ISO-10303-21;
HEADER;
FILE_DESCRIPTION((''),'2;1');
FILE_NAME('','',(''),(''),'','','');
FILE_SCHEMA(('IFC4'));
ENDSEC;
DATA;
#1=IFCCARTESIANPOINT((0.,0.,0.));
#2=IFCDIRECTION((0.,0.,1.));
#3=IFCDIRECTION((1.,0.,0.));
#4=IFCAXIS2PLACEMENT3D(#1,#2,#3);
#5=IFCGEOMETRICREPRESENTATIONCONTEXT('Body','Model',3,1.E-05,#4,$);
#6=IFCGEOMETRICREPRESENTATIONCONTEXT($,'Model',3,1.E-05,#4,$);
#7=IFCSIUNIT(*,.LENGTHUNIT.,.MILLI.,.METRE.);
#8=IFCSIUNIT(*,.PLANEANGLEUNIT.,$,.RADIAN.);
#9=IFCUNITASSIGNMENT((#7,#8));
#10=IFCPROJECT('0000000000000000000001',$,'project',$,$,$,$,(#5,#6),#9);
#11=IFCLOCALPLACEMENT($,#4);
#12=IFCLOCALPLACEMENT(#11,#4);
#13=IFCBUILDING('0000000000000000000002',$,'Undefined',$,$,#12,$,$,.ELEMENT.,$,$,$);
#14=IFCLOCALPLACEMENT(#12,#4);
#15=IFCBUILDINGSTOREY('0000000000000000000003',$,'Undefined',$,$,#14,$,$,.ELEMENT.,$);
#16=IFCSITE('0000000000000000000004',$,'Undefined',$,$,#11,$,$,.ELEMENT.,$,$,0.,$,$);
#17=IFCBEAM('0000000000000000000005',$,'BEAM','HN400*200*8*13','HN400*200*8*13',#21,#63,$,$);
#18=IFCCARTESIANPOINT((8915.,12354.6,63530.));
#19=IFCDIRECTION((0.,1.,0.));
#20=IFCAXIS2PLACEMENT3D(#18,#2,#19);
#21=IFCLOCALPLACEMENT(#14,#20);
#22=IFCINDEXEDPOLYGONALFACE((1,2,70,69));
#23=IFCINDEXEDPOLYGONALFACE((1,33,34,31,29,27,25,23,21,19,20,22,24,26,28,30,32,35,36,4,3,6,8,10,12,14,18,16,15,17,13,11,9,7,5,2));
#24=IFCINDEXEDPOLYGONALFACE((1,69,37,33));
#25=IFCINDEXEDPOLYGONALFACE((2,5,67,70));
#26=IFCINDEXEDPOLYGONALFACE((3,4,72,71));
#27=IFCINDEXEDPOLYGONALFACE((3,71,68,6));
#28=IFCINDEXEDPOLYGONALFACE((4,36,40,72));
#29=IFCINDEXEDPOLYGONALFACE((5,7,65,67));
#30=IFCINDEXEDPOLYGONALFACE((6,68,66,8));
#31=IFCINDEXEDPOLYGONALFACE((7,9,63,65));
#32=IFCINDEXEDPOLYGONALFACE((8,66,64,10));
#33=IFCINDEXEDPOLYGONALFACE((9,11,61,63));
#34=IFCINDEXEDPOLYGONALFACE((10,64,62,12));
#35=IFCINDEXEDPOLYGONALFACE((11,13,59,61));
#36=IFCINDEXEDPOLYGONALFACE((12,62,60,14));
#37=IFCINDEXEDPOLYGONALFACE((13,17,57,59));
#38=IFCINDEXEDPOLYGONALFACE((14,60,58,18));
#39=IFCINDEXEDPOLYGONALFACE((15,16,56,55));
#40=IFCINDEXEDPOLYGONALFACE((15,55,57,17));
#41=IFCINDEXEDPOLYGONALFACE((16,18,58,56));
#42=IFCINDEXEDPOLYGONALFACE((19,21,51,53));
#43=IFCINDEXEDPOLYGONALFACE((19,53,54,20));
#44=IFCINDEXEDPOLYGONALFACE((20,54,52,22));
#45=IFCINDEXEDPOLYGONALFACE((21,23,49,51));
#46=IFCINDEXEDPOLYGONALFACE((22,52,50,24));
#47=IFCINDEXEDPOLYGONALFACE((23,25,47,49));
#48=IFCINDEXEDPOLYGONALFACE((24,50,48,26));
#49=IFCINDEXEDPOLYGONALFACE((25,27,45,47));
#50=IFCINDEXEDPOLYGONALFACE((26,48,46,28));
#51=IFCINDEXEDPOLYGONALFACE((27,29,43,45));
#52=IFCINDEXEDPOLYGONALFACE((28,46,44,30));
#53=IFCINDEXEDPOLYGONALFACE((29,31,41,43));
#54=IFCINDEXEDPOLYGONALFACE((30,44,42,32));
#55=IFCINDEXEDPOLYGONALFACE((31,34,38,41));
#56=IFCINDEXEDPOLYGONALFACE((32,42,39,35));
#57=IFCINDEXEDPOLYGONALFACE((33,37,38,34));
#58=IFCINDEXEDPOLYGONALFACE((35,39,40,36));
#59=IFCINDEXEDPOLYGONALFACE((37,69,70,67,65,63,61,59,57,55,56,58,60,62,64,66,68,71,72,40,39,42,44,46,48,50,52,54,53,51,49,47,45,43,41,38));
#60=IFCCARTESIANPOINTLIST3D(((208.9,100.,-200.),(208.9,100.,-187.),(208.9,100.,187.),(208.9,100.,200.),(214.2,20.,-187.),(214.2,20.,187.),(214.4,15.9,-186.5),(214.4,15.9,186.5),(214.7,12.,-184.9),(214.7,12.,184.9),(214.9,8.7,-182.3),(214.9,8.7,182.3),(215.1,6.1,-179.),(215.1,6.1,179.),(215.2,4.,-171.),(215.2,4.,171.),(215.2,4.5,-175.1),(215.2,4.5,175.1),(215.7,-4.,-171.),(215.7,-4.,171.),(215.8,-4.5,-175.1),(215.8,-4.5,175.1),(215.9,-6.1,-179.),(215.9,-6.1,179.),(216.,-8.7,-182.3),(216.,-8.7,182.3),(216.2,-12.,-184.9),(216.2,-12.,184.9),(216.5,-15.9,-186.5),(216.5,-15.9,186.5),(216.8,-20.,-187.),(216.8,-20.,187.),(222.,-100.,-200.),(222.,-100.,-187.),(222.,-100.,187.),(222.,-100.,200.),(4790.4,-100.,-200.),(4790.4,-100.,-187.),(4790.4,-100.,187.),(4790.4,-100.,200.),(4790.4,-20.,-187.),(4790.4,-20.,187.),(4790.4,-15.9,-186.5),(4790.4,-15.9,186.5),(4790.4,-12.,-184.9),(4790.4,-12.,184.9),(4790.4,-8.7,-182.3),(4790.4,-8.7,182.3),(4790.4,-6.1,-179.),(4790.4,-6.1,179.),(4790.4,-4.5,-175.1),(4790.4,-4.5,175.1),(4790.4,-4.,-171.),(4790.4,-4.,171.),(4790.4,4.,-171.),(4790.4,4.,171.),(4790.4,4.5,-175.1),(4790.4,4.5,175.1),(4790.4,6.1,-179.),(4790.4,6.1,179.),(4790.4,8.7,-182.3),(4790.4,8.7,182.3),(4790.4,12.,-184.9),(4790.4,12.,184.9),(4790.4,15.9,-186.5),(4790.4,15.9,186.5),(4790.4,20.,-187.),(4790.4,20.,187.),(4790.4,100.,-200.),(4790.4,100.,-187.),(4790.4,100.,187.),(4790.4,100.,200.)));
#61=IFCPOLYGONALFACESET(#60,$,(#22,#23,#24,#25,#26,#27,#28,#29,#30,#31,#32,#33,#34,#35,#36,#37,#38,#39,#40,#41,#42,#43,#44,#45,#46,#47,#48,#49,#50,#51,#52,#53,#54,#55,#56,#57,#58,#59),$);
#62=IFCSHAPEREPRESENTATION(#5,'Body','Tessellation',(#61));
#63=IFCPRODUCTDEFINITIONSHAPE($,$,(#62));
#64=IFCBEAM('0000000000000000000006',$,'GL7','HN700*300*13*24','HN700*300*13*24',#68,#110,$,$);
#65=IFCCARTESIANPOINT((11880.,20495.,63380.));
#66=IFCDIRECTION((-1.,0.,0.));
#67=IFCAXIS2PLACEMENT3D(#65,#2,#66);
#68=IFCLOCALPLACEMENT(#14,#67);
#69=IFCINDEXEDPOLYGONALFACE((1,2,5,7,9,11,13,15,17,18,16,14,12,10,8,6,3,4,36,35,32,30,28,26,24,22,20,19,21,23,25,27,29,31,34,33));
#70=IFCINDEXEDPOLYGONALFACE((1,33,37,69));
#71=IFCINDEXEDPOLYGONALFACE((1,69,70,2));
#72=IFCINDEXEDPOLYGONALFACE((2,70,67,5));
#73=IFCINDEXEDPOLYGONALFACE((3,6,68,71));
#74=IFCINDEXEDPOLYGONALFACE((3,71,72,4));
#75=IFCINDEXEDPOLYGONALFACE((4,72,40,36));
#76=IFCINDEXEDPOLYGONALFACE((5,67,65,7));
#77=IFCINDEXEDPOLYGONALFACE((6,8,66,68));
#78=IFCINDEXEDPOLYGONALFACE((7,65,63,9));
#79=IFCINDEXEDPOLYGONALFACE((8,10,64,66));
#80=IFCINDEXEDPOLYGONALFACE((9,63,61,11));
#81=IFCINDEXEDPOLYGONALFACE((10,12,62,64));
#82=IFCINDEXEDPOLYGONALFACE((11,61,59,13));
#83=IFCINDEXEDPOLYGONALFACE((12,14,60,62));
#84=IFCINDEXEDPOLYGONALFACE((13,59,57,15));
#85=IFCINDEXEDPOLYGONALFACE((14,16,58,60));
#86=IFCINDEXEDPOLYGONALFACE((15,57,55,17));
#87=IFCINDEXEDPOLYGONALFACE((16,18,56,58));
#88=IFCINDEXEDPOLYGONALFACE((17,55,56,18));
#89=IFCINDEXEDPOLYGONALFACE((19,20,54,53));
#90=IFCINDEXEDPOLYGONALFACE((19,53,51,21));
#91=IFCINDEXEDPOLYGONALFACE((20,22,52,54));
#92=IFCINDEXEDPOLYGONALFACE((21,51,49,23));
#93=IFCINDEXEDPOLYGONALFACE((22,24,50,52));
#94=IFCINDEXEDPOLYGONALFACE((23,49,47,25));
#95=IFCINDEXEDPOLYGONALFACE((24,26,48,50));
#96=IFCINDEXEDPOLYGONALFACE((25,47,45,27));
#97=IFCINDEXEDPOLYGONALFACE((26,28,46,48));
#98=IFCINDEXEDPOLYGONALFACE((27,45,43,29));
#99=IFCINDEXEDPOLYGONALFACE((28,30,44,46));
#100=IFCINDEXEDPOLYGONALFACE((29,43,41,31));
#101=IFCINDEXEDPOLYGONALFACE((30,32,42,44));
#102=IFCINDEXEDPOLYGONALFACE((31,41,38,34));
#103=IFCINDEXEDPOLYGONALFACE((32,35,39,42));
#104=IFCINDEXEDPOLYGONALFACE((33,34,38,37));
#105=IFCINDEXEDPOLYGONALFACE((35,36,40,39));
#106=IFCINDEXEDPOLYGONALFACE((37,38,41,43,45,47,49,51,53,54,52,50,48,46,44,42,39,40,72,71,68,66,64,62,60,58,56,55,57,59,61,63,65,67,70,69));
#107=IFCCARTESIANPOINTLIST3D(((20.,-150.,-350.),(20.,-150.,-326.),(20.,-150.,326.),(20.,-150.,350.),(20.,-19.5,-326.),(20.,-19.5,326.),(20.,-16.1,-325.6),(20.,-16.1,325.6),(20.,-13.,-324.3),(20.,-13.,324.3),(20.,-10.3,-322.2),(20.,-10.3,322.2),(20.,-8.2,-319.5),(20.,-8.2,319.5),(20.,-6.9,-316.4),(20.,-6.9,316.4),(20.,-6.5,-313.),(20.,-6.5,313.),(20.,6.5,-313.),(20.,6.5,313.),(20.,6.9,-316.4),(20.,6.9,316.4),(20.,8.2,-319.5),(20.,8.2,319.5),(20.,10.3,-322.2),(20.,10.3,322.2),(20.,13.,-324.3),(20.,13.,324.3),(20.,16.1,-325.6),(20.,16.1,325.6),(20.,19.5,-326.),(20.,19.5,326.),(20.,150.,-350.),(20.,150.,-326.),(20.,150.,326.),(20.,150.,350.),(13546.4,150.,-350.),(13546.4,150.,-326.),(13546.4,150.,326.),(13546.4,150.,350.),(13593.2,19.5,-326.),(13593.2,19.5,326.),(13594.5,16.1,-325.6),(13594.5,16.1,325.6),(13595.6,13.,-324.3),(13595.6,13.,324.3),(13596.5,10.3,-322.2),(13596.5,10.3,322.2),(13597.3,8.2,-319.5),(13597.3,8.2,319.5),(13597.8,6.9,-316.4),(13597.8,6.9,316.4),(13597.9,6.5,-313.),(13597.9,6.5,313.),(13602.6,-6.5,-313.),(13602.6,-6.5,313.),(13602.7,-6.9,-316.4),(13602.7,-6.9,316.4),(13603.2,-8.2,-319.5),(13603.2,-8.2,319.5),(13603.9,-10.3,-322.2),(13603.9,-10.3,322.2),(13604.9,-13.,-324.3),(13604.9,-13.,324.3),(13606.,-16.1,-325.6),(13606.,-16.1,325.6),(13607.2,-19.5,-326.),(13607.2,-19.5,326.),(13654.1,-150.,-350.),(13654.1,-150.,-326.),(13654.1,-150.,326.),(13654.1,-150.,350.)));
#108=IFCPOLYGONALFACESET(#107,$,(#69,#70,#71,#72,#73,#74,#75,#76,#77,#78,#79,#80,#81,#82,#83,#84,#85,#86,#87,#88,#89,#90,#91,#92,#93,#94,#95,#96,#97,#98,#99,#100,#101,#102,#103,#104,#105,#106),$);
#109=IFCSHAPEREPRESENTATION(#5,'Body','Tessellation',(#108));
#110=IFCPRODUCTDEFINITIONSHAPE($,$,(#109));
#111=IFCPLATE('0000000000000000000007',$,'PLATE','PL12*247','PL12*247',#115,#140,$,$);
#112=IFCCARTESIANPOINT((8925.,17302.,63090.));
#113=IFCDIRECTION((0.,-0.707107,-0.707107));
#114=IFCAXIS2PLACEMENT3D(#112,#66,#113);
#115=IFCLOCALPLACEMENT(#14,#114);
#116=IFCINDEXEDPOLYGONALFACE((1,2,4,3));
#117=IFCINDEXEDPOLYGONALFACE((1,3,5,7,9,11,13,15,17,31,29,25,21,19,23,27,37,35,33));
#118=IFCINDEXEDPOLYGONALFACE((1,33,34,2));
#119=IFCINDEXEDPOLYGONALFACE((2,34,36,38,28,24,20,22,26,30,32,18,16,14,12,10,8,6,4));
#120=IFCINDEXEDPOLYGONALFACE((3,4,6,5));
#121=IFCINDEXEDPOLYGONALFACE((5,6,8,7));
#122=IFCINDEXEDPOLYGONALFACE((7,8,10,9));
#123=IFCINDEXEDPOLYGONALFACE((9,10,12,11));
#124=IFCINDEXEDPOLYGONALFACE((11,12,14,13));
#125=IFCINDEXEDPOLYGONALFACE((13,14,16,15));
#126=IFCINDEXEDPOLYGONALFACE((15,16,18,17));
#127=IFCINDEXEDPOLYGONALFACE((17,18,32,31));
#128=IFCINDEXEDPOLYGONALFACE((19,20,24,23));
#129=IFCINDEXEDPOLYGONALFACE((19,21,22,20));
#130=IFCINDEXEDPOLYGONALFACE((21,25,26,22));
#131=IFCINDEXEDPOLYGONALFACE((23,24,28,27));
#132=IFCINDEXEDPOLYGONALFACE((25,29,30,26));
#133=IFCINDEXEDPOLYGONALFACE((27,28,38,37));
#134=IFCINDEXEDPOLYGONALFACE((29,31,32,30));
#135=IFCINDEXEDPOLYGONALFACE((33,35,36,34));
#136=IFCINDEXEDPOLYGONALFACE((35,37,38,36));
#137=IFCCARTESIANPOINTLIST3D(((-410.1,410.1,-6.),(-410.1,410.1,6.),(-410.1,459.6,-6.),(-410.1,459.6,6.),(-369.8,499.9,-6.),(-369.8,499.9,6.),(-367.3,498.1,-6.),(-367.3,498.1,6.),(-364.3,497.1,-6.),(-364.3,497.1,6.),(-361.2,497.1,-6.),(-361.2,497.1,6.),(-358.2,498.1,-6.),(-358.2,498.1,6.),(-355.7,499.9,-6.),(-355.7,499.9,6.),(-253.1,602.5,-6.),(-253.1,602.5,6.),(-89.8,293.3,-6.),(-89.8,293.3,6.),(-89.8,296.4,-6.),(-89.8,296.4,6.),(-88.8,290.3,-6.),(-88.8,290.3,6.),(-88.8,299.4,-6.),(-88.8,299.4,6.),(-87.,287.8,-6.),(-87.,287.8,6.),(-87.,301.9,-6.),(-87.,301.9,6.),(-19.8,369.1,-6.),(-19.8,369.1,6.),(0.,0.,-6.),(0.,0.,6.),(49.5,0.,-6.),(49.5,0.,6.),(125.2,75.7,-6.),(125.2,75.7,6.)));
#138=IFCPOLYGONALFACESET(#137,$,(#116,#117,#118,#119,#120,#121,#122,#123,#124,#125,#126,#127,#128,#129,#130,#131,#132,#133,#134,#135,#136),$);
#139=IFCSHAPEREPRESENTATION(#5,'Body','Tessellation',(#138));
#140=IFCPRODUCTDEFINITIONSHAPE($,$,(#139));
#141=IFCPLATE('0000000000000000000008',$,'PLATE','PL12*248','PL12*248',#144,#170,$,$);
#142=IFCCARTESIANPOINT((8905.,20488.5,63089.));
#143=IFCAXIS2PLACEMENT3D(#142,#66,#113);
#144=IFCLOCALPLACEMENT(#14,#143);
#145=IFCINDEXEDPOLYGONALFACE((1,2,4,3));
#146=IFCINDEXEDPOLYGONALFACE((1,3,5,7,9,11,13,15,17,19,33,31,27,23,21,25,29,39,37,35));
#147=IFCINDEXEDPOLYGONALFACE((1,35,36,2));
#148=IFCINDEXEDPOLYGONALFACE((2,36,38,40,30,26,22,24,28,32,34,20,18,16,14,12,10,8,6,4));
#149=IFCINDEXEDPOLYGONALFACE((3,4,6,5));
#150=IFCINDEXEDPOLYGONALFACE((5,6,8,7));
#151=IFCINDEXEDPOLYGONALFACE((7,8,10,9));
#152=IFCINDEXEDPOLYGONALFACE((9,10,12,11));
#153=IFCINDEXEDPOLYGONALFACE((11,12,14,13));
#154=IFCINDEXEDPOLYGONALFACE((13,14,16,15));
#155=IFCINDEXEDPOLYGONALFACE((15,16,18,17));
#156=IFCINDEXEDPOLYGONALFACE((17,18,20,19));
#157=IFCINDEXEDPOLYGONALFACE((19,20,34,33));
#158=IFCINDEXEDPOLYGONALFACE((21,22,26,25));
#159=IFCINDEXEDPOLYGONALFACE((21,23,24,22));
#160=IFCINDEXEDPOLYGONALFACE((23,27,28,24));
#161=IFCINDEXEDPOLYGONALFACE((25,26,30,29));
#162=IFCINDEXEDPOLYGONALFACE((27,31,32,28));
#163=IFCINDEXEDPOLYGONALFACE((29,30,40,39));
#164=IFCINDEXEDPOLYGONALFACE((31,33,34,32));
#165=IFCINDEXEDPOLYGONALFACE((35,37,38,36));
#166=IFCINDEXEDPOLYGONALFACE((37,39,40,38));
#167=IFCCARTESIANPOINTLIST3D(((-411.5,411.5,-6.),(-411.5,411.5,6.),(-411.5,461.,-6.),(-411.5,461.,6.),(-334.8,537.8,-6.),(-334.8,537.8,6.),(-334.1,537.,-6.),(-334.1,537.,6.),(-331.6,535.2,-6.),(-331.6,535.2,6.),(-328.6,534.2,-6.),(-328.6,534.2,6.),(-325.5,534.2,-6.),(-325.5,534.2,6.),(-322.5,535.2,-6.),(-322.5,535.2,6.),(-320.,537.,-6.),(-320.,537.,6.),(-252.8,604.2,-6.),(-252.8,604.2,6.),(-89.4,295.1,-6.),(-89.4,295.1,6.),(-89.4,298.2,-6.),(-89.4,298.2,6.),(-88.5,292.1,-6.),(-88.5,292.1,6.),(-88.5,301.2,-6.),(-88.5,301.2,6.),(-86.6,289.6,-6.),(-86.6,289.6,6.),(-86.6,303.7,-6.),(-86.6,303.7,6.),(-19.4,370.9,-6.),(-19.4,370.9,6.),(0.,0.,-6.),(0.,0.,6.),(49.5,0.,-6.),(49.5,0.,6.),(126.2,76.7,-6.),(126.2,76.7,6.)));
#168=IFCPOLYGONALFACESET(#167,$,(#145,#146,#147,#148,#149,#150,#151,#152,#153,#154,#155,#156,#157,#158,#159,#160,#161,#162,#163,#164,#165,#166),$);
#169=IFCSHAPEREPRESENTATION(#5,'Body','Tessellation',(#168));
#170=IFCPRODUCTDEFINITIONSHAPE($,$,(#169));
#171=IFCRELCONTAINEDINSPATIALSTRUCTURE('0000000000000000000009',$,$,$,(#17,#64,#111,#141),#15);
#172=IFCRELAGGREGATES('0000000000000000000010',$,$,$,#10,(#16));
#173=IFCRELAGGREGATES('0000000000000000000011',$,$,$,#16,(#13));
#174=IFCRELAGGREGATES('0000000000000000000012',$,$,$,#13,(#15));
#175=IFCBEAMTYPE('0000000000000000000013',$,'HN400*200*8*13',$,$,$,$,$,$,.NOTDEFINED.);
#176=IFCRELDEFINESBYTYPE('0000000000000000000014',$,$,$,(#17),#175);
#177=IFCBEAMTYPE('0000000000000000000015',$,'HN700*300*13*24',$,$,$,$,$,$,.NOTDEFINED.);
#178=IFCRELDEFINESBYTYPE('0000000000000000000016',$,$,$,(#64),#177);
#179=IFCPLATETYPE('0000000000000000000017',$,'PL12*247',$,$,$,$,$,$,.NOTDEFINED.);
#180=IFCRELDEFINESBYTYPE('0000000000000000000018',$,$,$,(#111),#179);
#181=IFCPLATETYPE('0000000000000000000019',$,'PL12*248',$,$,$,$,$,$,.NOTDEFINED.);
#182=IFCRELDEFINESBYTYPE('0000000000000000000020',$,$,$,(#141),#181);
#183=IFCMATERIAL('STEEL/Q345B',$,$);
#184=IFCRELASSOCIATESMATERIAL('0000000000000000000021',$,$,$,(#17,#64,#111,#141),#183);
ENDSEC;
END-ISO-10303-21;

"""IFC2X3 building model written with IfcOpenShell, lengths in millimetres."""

from ifc_helpers import new_model, si_unit, frame, origin_with_axes, origin_2d_with_axis, place, context, project, spatial, polyline, i_section, outline, extrude, clip, halfspace, material, type_object, element, save


model = new_model("IFC2X3")

# Units and contexts
model_context_1 = context("Model", 3, precision=1e-05, world=origin_with_axes(), identifier="Body")
model_context_2 = context("Model", 3, precision=1e-05, world=origin_with_axes())
ifc_project = project(units=[si_unit("LENGTHUNIT", "METRE", prefix="MILLI"), si_unit("PLANEANGLEUNIT", "RADIAN")], contexts=[model_context_1, model_context_2])

# Site, building, storey
site_placement = place(None, origin_with_axes())
site = spatial("IfcSite", under=ifc_project, at=site_placement, Name="Undefined", CompositionType="ELEMENT", RefElevation=0.0)
building_placement = place(site_placement, origin_with_axes())
building = spatial("IfcBuilding", under=site, at=building_placement, Name="Undefined", CompositionType="ELEMENT")
storey_placement = place(building_placement, origin_with_axes())
storey = spatial("IfcBuildingStorey", under=building, at=storey_placement, Name="Undefined", CompositionType="ELEMENT")

# Shared definitions
ifc_material_1 = material(Name="STEEL/Q345B")

# Beams
beam_type_1 = type_object("IfcBeamType", Name="HN400*200*8*13", PredefinedType="NOTDEFINED")
beam_1_placement = place(storey_placement, frame((8915.0, 12354.6, 63530.0), z_axis=(0.0, 0.0, 1.0), x_axis=(0.0, 1.0, 0.0)))
element("IfcBeam", 1, at=beam_1_placement, inside=storey, type_object=beam_type_1, material=ifc_material_1, Name="BEAM", Description="HN400*200*8*13", ObjectType="HN400*200*8*13", context=model_context_1, shape_type="Clipping", body=[
    clip(clip(extrude(i_section(OverallWidth=200.0, OverallDepth=400.0, WebThickness=8.0, FlangeThickness=13.0, FilletRadius=16.0, at=origin_2d_with_axis()), frame((4790.4, 0.0, 0.0), z_axis=(-1.0, 0.0, 0.0), x_axis=(0.0, -1.0, 0.0)), (0.0, 0.0, 1.0), 4581.6), halfspace(frame((214.6, 13.2, 300.0), z_axis=(-0.997873, -0.065183, 0.0), x_axis=(0.0, 0.0, -1.0)), False)), halfspace(frame((4790.4, 0.0, 300.0), z_axis=(1.0, 0.0, 0.0), x_axis=(0.0, 0.0, -1.0)), False)),
])
beam_type_2 = type_object("IfcBeamType", Name="HN700*300*13*24", PredefinedType="NOTDEFINED")
beam_2_placement = place(storey_placement, frame((11880.0, 20495.0, 63380.0), z_axis=(0.0, 0.0, 1.0), x_axis=(-1.0, 0.0, 0.0)))
element("IfcBeam", 2, at=beam_2_placement, inside=storey, type_object=beam_type_2, material=ifc_material_1, Name="GL7", Description="HN700*300*13*24", ObjectType="HN700*300*13*24", context=model_context_1, shape_type="Clipping", body=[
    clip(clip(clip(extrude(i_section(OverallWidth=300.0, OverallDepth=700.0, WebThickness=13.0, FlangeThickness=24.0, FilletRadius=13.0, at=origin_2d_with_axis()), frame((13654.6, 0.0, 0.0), z_axis=(-1.0, 0.0, 0.0), x_axis=(0.0, -1.0, 0.0)), (0.0, 0.0, 1.0), 13634.6), halfspace(frame((20.0, -157.8, 700.0), z_axis=(-1.0, 0.0, 0.0), x_axis=(0.0, 1.0, 0.0)), False)), halfspace(frame((13688.5, -61.0, 350.0), z_axis=(-0.941212, -0.337816, 0.0), x_axis=(-0.337816, 0.941212, 0.0)), True)), halfspace(frame((13619.3, -53.0, 450.0), z_axis=(0.941212, 0.337816, 0.0), x_axis=(-0.337816, 0.941212, 0.0)), False)),
])

# Plates
plate_type_1 = type_object("IfcPlateType", Name="PL12*247", PredefinedType="NOTDEFINED")
for number, where, z_axis, x_axis, name in (
    (3, (8925.0, 17302.0, 63090.0), (-1.0, 0.0, 0.0), (0.0, -0.707107, -0.707107), "PLATE"),
):
    element("IfcPlate", number, at=place(storey_placement, frame(where, z_axis=z_axis, x_axis=x_axis)), inside=storey, type_object=plate_type_1, material=ifc_material_1, Name=name, Description="PL12*247", ObjectType="PL12*247", context=model_context_1, shape_type="SweptSolid", body=[
        extrude(outline(polyline([(0.0, 0.0), (49.5, 0.0), (125.2, 75.7), (-87.0, 287.8), (-88.8, 290.3), (-89.8, 293.3), (-89.8, 296.4), (-88.8, 299.4), (-87.0, 301.9), (-19.8, 369.1), (-253.1, 602.5), (-355.7, 499.9), (-358.2, 498.1), (-361.2, 497.1), (-364.3, 497.1), (-367.3, 498.1), (-369.8, 499.9), (-410.1, 459.6), (-410.1, 410.1), (0.0, 0.0)])), frame((0.0, 0.0, -6.0), z_axis=(0.0, 0.0, 1.0), x_axis=(1.0, 0.0, 0.0)), (0.0, 0.0, 1.0), 12.0),
    ])
plate_type_2 = type_object("IfcPlateType", Name="PL12*248", PredefinedType="NOTDEFINED")
for number, where, z_axis, x_axis, name in (
    (4, (8905.0, 20488.5, 63089.0), (-1.0, 0.0, 0.0), (0.0, -0.707107, -0.707107), "PLATE"),
):
    element("IfcPlate", number, at=place(storey_placement, frame(where, z_axis=z_axis, x_axis=x_axis)), inside=storey, type_object=plate_type_2, material=ifc_material_1, Name=name, Description="PL12*248", ObjectType="PL12*248", context=model_context_1, shape_type="SweptSolid", body=[
        extrude(outline(polyline([(0.0, 0.0), (49.5, 0.0), (126.2, 76.7), (-86.6, 289.6), (-88.5, 292.1), (-89.4, 295.1), (-89.4, 298.2), (-88.5, 301.2), (-86.6, 303.7), (-19.4, 370.9), (-252.8, 604.2), (-320.0, 537.0), (-322.5, 535.2), (-325.5, 534.2), (-328.6, 534.2), (-331.6, 535.2), (-334.1, 537.0), (-334.8, 537.8), (-411.5, 461.0), (-411.5, 411.5), (0.0, 0.0)])), frame((0.0, 0.0, -6.0), z_axis=(0.0, 0.0, 1.0), x_axis=(1.0, 0.0, 0.0)), (0.0, 0.0, 1.0), 12.0),
    ])

save(model, "model.ifc")
